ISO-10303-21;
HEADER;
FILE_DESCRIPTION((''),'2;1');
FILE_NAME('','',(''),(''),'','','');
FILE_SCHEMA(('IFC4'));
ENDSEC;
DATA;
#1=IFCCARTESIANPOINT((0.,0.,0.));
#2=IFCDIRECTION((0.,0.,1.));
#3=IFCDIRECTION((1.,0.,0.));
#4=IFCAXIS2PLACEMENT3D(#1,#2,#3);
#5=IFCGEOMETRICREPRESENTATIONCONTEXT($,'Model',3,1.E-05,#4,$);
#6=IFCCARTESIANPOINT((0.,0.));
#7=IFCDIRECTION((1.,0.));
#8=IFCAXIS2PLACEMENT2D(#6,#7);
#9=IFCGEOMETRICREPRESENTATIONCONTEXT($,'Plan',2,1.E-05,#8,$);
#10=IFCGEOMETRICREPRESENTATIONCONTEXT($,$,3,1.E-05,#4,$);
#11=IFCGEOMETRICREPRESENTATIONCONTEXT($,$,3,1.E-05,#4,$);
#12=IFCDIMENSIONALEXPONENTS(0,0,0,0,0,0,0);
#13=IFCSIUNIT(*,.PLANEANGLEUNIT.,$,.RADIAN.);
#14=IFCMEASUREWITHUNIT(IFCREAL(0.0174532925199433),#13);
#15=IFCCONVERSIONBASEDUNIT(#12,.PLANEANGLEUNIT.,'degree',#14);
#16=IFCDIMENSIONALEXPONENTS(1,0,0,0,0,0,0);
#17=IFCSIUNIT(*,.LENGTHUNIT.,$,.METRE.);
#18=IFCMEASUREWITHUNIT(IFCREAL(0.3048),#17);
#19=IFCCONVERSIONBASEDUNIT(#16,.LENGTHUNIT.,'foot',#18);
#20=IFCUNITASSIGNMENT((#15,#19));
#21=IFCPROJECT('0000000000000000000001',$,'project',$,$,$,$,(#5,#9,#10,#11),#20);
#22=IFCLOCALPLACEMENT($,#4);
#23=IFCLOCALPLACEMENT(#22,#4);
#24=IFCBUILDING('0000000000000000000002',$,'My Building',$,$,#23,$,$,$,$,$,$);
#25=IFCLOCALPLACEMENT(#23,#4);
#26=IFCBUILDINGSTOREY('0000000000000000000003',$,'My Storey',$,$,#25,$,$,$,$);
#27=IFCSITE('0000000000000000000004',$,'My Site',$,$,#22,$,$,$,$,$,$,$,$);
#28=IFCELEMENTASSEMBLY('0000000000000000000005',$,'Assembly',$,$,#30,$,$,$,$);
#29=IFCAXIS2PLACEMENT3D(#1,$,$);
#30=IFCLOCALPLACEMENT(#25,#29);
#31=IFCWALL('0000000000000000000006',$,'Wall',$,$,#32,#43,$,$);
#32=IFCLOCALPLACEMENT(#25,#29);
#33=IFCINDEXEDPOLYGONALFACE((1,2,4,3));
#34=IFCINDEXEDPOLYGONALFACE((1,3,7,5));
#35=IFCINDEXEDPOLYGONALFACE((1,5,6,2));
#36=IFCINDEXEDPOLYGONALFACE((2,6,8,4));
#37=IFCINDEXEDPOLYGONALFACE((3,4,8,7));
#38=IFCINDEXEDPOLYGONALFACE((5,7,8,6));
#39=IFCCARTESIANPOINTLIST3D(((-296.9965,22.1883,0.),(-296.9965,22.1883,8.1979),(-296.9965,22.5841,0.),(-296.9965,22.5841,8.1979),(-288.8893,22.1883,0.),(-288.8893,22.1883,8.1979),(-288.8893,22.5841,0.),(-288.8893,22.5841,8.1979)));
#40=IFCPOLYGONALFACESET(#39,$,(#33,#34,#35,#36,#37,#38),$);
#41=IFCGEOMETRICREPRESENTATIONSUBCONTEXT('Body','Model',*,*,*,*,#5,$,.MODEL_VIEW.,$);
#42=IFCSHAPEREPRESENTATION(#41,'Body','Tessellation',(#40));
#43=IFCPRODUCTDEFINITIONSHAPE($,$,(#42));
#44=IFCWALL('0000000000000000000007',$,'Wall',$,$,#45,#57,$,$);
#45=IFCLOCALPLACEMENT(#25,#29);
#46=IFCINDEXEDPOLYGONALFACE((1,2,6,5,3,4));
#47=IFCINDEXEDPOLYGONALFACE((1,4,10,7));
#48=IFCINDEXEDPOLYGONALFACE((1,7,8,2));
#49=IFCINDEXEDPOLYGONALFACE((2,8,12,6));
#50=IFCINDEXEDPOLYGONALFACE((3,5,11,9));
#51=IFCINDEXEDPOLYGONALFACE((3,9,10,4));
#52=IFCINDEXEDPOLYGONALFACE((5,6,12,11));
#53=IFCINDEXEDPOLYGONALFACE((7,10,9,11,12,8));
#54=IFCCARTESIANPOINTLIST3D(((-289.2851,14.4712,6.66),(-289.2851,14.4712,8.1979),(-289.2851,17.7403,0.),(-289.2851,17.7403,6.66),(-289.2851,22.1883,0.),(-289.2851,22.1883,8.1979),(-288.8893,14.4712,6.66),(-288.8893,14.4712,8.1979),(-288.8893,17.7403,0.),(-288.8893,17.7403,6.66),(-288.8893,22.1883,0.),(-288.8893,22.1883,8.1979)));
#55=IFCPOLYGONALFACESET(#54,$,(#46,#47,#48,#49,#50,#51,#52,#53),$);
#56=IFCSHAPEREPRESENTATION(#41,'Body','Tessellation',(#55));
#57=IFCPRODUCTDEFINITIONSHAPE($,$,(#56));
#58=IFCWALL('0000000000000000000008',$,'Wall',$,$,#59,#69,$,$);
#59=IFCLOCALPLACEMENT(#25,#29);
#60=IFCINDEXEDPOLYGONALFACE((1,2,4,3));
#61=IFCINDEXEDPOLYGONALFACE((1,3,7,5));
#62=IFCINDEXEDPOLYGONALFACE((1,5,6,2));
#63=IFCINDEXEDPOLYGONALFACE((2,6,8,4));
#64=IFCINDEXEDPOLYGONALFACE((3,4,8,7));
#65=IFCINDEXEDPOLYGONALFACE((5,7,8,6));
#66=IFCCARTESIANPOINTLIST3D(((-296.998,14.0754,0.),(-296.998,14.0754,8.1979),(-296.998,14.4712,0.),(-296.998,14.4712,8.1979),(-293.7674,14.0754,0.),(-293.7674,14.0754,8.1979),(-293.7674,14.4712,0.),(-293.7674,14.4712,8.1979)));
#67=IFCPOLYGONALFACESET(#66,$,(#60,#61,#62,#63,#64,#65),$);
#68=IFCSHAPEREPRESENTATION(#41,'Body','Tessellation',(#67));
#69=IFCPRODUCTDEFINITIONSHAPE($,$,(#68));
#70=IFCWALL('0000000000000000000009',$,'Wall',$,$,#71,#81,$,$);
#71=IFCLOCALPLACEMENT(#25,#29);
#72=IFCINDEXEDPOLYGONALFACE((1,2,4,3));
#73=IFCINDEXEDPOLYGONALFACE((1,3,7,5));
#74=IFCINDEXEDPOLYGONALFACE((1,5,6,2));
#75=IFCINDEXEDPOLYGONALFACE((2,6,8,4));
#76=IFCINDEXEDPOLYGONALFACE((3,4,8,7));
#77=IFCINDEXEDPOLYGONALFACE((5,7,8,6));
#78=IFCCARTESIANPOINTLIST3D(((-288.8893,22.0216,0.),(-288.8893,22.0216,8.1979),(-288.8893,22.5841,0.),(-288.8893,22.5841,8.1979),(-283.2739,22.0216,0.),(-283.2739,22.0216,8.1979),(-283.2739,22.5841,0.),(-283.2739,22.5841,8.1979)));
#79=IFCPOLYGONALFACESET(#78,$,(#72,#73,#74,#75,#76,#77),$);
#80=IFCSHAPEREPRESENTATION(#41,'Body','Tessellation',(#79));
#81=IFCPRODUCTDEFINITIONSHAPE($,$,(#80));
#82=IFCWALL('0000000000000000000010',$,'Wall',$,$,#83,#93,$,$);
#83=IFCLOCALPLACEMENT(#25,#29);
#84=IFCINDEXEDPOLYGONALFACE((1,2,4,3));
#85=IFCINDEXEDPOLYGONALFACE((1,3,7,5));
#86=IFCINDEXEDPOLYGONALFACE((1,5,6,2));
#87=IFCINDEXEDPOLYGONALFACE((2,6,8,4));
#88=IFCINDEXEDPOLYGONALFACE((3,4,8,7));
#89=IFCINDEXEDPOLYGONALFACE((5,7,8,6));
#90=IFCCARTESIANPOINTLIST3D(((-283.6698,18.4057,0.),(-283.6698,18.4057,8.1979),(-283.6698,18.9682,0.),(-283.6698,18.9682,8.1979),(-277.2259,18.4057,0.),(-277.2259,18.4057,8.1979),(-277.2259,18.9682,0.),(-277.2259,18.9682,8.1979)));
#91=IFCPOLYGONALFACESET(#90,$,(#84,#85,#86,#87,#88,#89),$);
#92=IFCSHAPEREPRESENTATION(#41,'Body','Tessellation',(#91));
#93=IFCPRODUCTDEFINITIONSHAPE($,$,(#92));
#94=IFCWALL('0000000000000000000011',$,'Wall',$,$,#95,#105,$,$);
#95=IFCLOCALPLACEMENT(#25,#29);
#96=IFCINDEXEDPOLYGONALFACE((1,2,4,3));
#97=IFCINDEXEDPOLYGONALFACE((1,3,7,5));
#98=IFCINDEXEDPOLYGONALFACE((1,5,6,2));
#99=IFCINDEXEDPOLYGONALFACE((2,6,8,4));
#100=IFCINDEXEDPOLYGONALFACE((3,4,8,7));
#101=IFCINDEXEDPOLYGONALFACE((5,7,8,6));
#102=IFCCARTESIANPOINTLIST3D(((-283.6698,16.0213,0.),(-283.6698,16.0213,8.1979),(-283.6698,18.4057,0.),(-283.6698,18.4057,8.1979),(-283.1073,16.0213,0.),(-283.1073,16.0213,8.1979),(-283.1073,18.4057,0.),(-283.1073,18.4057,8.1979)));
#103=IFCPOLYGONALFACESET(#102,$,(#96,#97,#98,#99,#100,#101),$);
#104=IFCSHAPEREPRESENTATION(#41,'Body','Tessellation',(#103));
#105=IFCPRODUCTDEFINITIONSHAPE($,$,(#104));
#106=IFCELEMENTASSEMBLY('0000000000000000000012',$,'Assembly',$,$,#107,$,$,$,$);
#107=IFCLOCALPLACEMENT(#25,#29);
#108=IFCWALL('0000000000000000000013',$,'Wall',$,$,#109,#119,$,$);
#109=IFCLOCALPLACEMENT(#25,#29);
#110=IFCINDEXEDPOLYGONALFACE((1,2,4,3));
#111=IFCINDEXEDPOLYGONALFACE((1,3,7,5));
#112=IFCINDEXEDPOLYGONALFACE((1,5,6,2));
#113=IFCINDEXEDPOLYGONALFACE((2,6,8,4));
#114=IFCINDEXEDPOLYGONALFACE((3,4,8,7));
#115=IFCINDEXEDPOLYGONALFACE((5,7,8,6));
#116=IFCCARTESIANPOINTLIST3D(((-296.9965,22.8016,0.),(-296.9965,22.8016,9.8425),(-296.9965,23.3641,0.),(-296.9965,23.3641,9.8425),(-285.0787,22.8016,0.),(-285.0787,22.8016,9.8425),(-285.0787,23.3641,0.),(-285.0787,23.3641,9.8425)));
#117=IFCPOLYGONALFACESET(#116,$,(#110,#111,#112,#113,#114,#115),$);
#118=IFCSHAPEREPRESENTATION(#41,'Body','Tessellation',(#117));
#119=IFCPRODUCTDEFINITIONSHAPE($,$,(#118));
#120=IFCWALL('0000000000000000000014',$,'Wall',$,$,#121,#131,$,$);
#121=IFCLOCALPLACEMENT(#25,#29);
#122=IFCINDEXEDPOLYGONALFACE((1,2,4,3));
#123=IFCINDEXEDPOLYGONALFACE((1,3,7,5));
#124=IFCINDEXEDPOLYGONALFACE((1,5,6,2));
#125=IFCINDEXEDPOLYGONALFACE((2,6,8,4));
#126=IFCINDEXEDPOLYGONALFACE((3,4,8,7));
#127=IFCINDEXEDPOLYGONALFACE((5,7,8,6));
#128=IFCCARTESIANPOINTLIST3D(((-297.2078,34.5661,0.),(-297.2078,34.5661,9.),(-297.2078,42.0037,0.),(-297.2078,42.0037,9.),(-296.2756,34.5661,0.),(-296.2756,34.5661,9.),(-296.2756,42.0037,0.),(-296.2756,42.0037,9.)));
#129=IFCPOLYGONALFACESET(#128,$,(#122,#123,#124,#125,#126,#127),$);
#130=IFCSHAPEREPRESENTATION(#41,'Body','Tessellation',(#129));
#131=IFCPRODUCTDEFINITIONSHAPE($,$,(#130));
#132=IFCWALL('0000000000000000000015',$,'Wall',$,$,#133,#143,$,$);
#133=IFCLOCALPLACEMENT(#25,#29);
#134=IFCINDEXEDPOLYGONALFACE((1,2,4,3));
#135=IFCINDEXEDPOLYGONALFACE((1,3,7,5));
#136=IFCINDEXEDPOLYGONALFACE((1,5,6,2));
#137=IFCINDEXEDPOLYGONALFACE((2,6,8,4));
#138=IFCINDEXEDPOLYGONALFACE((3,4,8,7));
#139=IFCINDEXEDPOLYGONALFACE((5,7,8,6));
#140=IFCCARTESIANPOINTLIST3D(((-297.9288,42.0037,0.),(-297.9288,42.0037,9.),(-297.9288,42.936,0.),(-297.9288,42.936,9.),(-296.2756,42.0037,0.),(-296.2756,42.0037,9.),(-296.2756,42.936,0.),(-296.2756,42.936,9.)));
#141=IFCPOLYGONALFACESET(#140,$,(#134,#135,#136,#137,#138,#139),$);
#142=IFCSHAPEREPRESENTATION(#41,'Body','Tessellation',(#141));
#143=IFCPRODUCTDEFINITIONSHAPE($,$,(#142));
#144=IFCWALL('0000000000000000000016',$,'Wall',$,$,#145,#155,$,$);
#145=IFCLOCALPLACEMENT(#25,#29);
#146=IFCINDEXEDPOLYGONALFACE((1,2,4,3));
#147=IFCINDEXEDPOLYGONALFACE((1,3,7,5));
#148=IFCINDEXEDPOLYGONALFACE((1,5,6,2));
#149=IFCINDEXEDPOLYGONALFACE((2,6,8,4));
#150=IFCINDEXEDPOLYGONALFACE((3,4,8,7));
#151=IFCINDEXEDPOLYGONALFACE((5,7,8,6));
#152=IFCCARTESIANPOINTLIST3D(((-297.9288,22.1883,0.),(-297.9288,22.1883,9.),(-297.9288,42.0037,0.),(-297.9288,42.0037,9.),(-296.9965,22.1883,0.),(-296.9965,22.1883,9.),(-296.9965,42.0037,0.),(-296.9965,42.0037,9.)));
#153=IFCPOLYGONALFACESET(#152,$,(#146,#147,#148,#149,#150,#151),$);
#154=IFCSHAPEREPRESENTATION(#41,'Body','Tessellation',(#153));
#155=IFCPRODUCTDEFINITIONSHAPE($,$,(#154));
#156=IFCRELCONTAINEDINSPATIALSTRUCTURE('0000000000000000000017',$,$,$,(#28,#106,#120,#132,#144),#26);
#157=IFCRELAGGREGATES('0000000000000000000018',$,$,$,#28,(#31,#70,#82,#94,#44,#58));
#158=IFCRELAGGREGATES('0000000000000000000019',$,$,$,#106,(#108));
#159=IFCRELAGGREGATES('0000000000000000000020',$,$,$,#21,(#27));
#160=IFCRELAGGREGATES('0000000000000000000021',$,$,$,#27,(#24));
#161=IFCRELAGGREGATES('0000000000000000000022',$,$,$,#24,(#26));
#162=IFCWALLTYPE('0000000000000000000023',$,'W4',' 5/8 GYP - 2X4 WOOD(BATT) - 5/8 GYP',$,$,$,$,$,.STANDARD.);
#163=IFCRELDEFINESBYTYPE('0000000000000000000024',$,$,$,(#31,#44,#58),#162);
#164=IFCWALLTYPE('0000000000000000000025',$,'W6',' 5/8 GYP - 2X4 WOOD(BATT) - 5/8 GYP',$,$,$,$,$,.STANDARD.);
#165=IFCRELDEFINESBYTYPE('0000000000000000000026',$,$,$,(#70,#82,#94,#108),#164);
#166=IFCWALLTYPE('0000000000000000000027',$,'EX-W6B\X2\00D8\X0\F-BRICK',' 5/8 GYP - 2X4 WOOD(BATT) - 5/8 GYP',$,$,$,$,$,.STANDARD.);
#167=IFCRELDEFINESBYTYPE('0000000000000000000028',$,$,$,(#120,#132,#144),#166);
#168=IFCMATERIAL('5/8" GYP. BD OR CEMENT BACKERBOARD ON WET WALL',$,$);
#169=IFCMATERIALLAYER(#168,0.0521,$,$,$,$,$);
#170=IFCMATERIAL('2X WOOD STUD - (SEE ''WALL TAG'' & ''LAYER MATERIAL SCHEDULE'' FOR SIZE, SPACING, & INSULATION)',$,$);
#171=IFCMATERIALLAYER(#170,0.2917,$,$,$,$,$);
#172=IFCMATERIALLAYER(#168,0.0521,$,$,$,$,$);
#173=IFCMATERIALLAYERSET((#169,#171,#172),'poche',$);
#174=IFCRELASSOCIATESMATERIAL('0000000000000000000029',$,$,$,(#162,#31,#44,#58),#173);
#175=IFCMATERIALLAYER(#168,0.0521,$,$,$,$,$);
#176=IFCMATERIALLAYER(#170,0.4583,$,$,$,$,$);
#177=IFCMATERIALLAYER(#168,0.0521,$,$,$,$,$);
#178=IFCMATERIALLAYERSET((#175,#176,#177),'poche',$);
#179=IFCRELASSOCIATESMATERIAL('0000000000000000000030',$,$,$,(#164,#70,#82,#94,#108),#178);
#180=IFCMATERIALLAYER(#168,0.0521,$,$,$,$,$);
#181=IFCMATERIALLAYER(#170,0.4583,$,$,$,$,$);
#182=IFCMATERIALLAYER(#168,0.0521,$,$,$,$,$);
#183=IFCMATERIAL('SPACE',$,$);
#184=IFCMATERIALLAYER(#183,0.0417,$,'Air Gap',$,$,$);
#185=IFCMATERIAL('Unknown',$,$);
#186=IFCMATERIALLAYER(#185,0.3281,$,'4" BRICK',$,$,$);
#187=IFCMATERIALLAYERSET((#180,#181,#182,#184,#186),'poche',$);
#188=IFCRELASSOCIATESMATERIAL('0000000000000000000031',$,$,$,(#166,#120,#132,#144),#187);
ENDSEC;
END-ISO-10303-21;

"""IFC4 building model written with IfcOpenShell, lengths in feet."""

from ifc_helpers import new_model, entity, si_unit, converted_unit, frame, origin_with_axes, origin_2d_with_axis, place, context, subcontext, project, spatial, line, indexed_curve, outline, extrude, material, layer, layer_set, layer_usage, type_object, element, aggregate, save


model = new_model("IFC4")

# Units and contexts
model_context = context("Model", 3, precision=1e-05, world=origin_with_axes())
plan_context = context("Plan", 2, precision=1e-05, world=origin_2d_with_axis())
context_of_model_1 = context(None, 3, precision=1e-05, world=origin_with_axes())
context_of_model_2 = context(None, 3, precision=1e-05, world=origin_with_axes())
body_context = subcontext(model_context, "Body", "Model", "MODEL_VIEW")
ifc_project = project(units=[converted_unit("PLANEANGLEUNIT", "degree", entity("IfcReal", 0.0174532925199433), si_unit("PLANEANGLEUNIT", "RADIAN"), dimensions=[0, 0, 0, 0, 0, 0, 0]), converted_unit("LENGTHUNIT", "foot", entity("IfcReal", 0.3048), si_unit("LENGTHUNIT", "METRE"), dimensions=[1, 0, 0, 0, 0, 0, 0])], contexts=[model_context, plan_context, context_of_model_1, context_of_model_2])

# Site, building, storey
site_placement = place(None, origin_with_axes())
site = spatial("IfcSite", under=ifc_project, at=site_placement, Name="My Site")
building_placement = place(site_placement, origin_with_axes())
building = spatial("IfcBuilding", under=site, at=building_placement, Name="My Building")
storey_placement = place(building_placement, origin_with_axes())
storey = spatial("IfcBuildingStorey", under=building, at=storey_placement, Name="My Storey")

# Element assembly, walls, opening
assembly_1_placement = place(storey_placement, origin_with_axes())
assembly_1 = element("IfcElementAssembly", 1, at=assembly_1_placement, inside=storey, Name="Assembly")
ifc_material_1 = material(Name="5/8\" GYP. BD OR CEMENT BACKERBOARD ON WET WALL")
ifc_layer_1 = layer(ifc_material_1, 0.0521)
ifc_material_2 = material(Name="2X WOOD STUD - (SEE 'WALL TAG' & 'LAYER MATERIAL SCHEDULE' FOR SIZE, SPACING, & INSULATION)")
ifc_layer_2 = layer(ifc_material_2, 0.2917)
ifc_layer_3 = layer(ifc_material_1, 0.0521)
ifc_layer_set_1 = layer_set([ifc_layer_1, ifc_layer_2, ifc_layer_3], Name="poche")
ifc_layer_usage_1 = layer_usage(ifc_layer_set_1, "AXIS2", "POSITIVE", 0.0)
wall_type_1 = type_object("IfcWallType", Name="W4", Description=" 5/8 GYP - 2X4 WOOD(BATT) - 5/8 GYP", PredefinedType="STANDARD", material=ifc_layer_set_1)
wall_1_placement = place(assembly_1_placement, frame((-296.9965, 22.1883, 0.0), z_axis=(0.0, 0.0, 1.0), x_axis=(1.0, 0.0, 0.0)))
wall_1 = element("IfcWall", 2, at=wall_1_placement, type_object=wall_type_1, material=ifc_layer_usage_1, Name="Wall", context=body_context, shape_type="SweptSolid", body=[
    extrude(outline(indexed_curve([(0.0, 0.0), (0.0, 0.3958), (8.1073, 0.3958), (8.1073, 0.0), (0.0, 0.0)], self_intersect=False)), origin_with_axes(), (0.0, 0.0, 1.0), 8.1979),
])
ifc_layer_usage_2 = layer_usage(ifc_layer_set_1, "AXIS2", "POSITIVE", 0.0)
wall_2_placement = place(assembly_1_placement, frame((-288.8893, 14.4712, 0.0), z_axis=(0.0, 0.0, 1.0), x_axis=(0.0, 1.0, 0.0)))
wall_2 = element("IfcWall", 3, at=wall_2_placement, type_object=wall_type_1, material=ifc_layer_usage_2, Name="Wall", context=body_context, shape_type="SweptSolid", body=[
    extrude(outline(indexed_curve([(0.0, 0.0), (0.0, 0.3958), (7.717, 0.3958), (7.717, 0.0), (0.0, 0.0)], self_intersect=False)), origin_with_axes(), (0.0, 0.0, 1.0), 8.1979),
])
opening_1_placement = place(wall_2_placement, frame((1.6345, 0.816, 3.33), z_axis=(0.0, -1.0, 0.0), x_axis=(0.0, 0.0, -1.0)))
element("IfcOpeningElement", 4, at=opening_1_placement, cuts=wall_2, context=body_context, shape_type="SweptSolid", body=[
    extrude(outline(indexed_curve([(-3.33, -1.6345), (3.33, -1.6345), (3.33, 1.6345), (-3.33, 1.6345)], segments=[line(4, 1), line(1, 2), line(2, 3), line(3, 4)], self_intersect=False)), frame((0.0, 0.0, 0.0), z_axis=(0.0, 0.0, -1.0), x_axis=(1.0, 0.0, 0.0)), (0.0, 0.0, -1.0), 1.317),
])
ifc_layer_usage_3 = layer_usage(ifc_layer_set_1, "AXIS2", "POSITIVE", 0.0)
wall_3_placement = place(assembly_1_placement, frame((-293.7674, 14.4712, 0.0), z_axis=(0.0, 0.0, 1.0), x_axis=(-1.0, 0.0, 0.0)))
wall_3 = element("IfcWall", 5, at=wall_3_placement, type_object=wall_type_1, material=ifc_layer_usage_3, Name="Wall", context=body_context, shape_type="SweptSolid", body=[
    extrude(outline(indexed_curve([(0.0, 0.0), (0.0, 0.3958), (3.2307, 0.3958), (3.2307, 0.0), (0.0, 0.0)], self_intersect=False)), origin_with_axes(), (0.0, 0.0, 1.0), 8.1979),
])
ifc_layer_4 = layer(ifc_material_1, 0.0521)
ifc_layer_5 = layer(ifc_material_2, 0.4583)
ifc_layer_6 = layer(ifc_material_1, 0.0521)
ifc_layer_set_2 = layer_set([ifc_layer_4, ifc_layer_5, ifc_layer_6], Name="poche")
ifc_layer_usage_4 = layer_usage(ifc_layer_set_2, "AXIS2", "POSITIVE", 0.0)
wall_type_2 = type_object("IfcWallType", Name="W6", Description=" 5/8 GYP - 2X4 WOOD(BATT) - 5/8 GYP", PredefinedType="STANDARD", material=ifc_layer_set_2)
wall_4_placement = place(assembly_1_placement, frame((-288.8893, 22.0216, 0.0), z_axis=(0.0, 0.0, 1.0), x_axis=(1.0, 0.0, 0.0)))
wall_4 = element("IfcWall", 6, at=wall_4_placement, type_object=wall_type_2, material=ifc_layer_usage_4, Name="Wall", context=body_context, shape_type="SweptSolid", body=[
    extrude(outline(indexed_curve([(0.0, 0.0), (0.0, 0.5625), (5.6153, 0.5625), (5.6153, 0.0), (0.0, 0.0)], self_intersect=False)), origin_with_axes(), (0.0, 0.0, 1.0), 8.1979),
])
ifc_layer_usage_5 = layer_usage(ifc_layer_set_2, "AXIS2", "POSITIVE", 0.0)
wall_5_placement = place(assembly_1_placement, frame((-283.6698, 18.4057, 0.0), z_axis=(0.0, 0.0, 1.0), x_axis=(1.0, 0.0, 0.0)))
wall_5 = element("IfcWall", 7, at=wall_5_placement, type_object=wall_type_2, material=ifc_layer_usage_5, Name="Wall", context=body_context, shape_type="SweptSolid", body=[
    extrude(outline(indexed_curve([(0.0, 0.0), (0.0, 0.5625), (6.4439, 0.5625), (6.4439, 0.0), (0.0, 0.0)], self_intersect=False)), origin_with_axes(), (0.0, 0.0, 1.0), 8.1979),
])
ifc_layer_usage_6 = layer_usage(ifc_layer_set_2, "AXIS2", "POSITIVE", 0.0)
wall_6_placement = place(assembly_1_placement, frame((-283.6698, 18.4057, 0.0), z_axis=(0.0, 0.0, 1.0), x_axis=(0.0, -1.0, 0.0)))
wall_6 = element("IfcWall", 8, at=wall_6_placement, type_object=wall_type_2, material=ifc_layer_usage_6, Name="Wall", context=body_context, shape_type="SweptSolid", body=[
    extrude(outline(indexed_curve([(0.0, 0.0), (0.0, 0.5625), (2.3844, 0.5625), (2.3844, 0.0), (0.0, 0.0)], self_intersect=False)), origin_with_axes(), (0.0, 0.0, 1.0), 8.1979),
])
aggregate(assembly_1, [wall_1, wall_4, wall_5, wall_6, wall_2, wall_3])

# Element assembly, wall
assembly_2_placement = place(storey_placement, origin_with_axes())
assembly_2 = element("IfcElementAssembly", 9, at=assembly_2_placement, inside=storey, Name="Assembly")
ifc_layer_usage_7 = layer_usage(ifc_layer_set_2, "AXIS2", "POSITIVE", 0.0)
wall_7_placement = place(assembly_2_placement, frame((-285.0787, 23.3641, 0.0), z_axis=(0.0, 0.0, 1.0), x_axis=(-1.0, 0.0, 0.0)))
wall_7 = element("IfcWall", 10, at=wall_7_placement, type_object=wall_type_2, material=ifc_layer_usage_7, Name="Wall", context=body_context, shape_type="SweptSolid", body=[
    extrude(outline(indexed_curve([(0.0, 0.0), (0.0, 0.5625), (11.9178, 0.5625), (11.9178, 0.0), (0.0, 0.0)], self_intersect=False)), origin_with_axes(), (0.0, 0.0, 1.0), 9.8425),
])
aggregate(assembly_2, [wall_7])

# Walls
ifc_layer_7 = layer(ifc_material_1, 0.0521)
ifc_layer_8 = layer(ifc_material_2, 0.4583)
ifc_layer_9 = layer(ifc_material_1, 0.0521)
ifc_material_3 = material(Name="SPACE")
ifc_layer_10 = layer(ifc_material_3, 0.0417, Name="Air Gap")
ifc_material_4 = material(Name="Unknown")
ifc_layer_11 = layer(ifc_material_4, 0.3281, Name="4\" BRICK")
ifc_layer_set_3 = layer_set([ifc_layer_7, ifc_layer_8, ifc_layer_9, ifc_layer_10, ifc_layer_11], Name="poche")
ifc_layer_usage_8 = layer_usage(ifc_layer_set_3, "AXIS2", "POSITIVE", 0.0)
wall_type_3 = type_object("IfcWallType", Name="EX-W6BØF-BRICK", Description=" 5/8 GYP - 2X4 WOOD(BATT) - 5/8 GYP", PredefinedType="STANDARD", material=ifc_layer_set_3)
wall_8_placement = place(storey_placement, frame((-297.2078, 42.0037, 0.0), z_axis=(0.0, 0.0, 1.0), x_axis=(-0.000001, -1.0, 0.0)))
element("IfcWall", 11, at=wall_8_placement, inside=storey, type_object=wall_type_3, material=ifc_layer_usage_8, Name="Wall", context=body_context, shape_type="SweptSolid", body=[
    extrude(outline(indexed_curve([(0.0, 0.0), (0.0, 0.9323), (7.4376, 0.9323), (7.4376, 0.0), (0.0, 0.0)], self_intersect=False)), origin_with_axes(), (0.0, 0.0, 1.0), 9.0),
])
ifc_layer_usage_9 = layer_usage(ifc_layer_set_3, "AXIS2", "POSITIVE", 0.0)
wall_9_placement = place(storey_placement, frame((-297.9288, 42.0037, 0.0), z_axis=(0.0, 0.0, 1.0), x_axis=(1.0, 0.0, 0.0)))
element("IfcWall", 12, at=wall_9_placement, inside=storey, type_object=wall_type_3, material=ifc_layer_usage_9, Name="Wall", context=body_context, shape_type="SweptSolid", body=[
    extrude(outline(indexed_curve([(0.0, 0.0), (0.0, 0.9323), (1.6532, 0.9323), (1.6532, 0.0), (0.0, 0.0)], self_intersect=False)), origin_with_axes(), (0.0, 0.0, 1.0), 9.0),
])
ifc_layer_usage_10 = layer_usage(ifc_layer_set_3, "AXIS2", "POSITIVE", 0.0)
wall_10_placement = place(storey_placement, frame((-296.9965, 22.1883, 0.0), z_axis=(0.0, 0.0, 1.0), x_axis=(0.0, 1.0, 0.0)))
element("IfcWall", 13, at=wall_10_placement, inside=storey, type_object=wall_type_3, material=ifc_layer_usage_10, Name="Wall", context=body_context, shape_type="SweptSolid", body=[
    extrude(outline(indexed_curve([(0.0, 0.0), (0.0, 0.9323), (19.8155, 0.9323), (19.8155, 0.0), (0.0, 0.0)], self_intersect=False)), origin_with_axes(), (0.0, 0.0, 1.0), 9.0),
])

save(model, "model.ifc")
